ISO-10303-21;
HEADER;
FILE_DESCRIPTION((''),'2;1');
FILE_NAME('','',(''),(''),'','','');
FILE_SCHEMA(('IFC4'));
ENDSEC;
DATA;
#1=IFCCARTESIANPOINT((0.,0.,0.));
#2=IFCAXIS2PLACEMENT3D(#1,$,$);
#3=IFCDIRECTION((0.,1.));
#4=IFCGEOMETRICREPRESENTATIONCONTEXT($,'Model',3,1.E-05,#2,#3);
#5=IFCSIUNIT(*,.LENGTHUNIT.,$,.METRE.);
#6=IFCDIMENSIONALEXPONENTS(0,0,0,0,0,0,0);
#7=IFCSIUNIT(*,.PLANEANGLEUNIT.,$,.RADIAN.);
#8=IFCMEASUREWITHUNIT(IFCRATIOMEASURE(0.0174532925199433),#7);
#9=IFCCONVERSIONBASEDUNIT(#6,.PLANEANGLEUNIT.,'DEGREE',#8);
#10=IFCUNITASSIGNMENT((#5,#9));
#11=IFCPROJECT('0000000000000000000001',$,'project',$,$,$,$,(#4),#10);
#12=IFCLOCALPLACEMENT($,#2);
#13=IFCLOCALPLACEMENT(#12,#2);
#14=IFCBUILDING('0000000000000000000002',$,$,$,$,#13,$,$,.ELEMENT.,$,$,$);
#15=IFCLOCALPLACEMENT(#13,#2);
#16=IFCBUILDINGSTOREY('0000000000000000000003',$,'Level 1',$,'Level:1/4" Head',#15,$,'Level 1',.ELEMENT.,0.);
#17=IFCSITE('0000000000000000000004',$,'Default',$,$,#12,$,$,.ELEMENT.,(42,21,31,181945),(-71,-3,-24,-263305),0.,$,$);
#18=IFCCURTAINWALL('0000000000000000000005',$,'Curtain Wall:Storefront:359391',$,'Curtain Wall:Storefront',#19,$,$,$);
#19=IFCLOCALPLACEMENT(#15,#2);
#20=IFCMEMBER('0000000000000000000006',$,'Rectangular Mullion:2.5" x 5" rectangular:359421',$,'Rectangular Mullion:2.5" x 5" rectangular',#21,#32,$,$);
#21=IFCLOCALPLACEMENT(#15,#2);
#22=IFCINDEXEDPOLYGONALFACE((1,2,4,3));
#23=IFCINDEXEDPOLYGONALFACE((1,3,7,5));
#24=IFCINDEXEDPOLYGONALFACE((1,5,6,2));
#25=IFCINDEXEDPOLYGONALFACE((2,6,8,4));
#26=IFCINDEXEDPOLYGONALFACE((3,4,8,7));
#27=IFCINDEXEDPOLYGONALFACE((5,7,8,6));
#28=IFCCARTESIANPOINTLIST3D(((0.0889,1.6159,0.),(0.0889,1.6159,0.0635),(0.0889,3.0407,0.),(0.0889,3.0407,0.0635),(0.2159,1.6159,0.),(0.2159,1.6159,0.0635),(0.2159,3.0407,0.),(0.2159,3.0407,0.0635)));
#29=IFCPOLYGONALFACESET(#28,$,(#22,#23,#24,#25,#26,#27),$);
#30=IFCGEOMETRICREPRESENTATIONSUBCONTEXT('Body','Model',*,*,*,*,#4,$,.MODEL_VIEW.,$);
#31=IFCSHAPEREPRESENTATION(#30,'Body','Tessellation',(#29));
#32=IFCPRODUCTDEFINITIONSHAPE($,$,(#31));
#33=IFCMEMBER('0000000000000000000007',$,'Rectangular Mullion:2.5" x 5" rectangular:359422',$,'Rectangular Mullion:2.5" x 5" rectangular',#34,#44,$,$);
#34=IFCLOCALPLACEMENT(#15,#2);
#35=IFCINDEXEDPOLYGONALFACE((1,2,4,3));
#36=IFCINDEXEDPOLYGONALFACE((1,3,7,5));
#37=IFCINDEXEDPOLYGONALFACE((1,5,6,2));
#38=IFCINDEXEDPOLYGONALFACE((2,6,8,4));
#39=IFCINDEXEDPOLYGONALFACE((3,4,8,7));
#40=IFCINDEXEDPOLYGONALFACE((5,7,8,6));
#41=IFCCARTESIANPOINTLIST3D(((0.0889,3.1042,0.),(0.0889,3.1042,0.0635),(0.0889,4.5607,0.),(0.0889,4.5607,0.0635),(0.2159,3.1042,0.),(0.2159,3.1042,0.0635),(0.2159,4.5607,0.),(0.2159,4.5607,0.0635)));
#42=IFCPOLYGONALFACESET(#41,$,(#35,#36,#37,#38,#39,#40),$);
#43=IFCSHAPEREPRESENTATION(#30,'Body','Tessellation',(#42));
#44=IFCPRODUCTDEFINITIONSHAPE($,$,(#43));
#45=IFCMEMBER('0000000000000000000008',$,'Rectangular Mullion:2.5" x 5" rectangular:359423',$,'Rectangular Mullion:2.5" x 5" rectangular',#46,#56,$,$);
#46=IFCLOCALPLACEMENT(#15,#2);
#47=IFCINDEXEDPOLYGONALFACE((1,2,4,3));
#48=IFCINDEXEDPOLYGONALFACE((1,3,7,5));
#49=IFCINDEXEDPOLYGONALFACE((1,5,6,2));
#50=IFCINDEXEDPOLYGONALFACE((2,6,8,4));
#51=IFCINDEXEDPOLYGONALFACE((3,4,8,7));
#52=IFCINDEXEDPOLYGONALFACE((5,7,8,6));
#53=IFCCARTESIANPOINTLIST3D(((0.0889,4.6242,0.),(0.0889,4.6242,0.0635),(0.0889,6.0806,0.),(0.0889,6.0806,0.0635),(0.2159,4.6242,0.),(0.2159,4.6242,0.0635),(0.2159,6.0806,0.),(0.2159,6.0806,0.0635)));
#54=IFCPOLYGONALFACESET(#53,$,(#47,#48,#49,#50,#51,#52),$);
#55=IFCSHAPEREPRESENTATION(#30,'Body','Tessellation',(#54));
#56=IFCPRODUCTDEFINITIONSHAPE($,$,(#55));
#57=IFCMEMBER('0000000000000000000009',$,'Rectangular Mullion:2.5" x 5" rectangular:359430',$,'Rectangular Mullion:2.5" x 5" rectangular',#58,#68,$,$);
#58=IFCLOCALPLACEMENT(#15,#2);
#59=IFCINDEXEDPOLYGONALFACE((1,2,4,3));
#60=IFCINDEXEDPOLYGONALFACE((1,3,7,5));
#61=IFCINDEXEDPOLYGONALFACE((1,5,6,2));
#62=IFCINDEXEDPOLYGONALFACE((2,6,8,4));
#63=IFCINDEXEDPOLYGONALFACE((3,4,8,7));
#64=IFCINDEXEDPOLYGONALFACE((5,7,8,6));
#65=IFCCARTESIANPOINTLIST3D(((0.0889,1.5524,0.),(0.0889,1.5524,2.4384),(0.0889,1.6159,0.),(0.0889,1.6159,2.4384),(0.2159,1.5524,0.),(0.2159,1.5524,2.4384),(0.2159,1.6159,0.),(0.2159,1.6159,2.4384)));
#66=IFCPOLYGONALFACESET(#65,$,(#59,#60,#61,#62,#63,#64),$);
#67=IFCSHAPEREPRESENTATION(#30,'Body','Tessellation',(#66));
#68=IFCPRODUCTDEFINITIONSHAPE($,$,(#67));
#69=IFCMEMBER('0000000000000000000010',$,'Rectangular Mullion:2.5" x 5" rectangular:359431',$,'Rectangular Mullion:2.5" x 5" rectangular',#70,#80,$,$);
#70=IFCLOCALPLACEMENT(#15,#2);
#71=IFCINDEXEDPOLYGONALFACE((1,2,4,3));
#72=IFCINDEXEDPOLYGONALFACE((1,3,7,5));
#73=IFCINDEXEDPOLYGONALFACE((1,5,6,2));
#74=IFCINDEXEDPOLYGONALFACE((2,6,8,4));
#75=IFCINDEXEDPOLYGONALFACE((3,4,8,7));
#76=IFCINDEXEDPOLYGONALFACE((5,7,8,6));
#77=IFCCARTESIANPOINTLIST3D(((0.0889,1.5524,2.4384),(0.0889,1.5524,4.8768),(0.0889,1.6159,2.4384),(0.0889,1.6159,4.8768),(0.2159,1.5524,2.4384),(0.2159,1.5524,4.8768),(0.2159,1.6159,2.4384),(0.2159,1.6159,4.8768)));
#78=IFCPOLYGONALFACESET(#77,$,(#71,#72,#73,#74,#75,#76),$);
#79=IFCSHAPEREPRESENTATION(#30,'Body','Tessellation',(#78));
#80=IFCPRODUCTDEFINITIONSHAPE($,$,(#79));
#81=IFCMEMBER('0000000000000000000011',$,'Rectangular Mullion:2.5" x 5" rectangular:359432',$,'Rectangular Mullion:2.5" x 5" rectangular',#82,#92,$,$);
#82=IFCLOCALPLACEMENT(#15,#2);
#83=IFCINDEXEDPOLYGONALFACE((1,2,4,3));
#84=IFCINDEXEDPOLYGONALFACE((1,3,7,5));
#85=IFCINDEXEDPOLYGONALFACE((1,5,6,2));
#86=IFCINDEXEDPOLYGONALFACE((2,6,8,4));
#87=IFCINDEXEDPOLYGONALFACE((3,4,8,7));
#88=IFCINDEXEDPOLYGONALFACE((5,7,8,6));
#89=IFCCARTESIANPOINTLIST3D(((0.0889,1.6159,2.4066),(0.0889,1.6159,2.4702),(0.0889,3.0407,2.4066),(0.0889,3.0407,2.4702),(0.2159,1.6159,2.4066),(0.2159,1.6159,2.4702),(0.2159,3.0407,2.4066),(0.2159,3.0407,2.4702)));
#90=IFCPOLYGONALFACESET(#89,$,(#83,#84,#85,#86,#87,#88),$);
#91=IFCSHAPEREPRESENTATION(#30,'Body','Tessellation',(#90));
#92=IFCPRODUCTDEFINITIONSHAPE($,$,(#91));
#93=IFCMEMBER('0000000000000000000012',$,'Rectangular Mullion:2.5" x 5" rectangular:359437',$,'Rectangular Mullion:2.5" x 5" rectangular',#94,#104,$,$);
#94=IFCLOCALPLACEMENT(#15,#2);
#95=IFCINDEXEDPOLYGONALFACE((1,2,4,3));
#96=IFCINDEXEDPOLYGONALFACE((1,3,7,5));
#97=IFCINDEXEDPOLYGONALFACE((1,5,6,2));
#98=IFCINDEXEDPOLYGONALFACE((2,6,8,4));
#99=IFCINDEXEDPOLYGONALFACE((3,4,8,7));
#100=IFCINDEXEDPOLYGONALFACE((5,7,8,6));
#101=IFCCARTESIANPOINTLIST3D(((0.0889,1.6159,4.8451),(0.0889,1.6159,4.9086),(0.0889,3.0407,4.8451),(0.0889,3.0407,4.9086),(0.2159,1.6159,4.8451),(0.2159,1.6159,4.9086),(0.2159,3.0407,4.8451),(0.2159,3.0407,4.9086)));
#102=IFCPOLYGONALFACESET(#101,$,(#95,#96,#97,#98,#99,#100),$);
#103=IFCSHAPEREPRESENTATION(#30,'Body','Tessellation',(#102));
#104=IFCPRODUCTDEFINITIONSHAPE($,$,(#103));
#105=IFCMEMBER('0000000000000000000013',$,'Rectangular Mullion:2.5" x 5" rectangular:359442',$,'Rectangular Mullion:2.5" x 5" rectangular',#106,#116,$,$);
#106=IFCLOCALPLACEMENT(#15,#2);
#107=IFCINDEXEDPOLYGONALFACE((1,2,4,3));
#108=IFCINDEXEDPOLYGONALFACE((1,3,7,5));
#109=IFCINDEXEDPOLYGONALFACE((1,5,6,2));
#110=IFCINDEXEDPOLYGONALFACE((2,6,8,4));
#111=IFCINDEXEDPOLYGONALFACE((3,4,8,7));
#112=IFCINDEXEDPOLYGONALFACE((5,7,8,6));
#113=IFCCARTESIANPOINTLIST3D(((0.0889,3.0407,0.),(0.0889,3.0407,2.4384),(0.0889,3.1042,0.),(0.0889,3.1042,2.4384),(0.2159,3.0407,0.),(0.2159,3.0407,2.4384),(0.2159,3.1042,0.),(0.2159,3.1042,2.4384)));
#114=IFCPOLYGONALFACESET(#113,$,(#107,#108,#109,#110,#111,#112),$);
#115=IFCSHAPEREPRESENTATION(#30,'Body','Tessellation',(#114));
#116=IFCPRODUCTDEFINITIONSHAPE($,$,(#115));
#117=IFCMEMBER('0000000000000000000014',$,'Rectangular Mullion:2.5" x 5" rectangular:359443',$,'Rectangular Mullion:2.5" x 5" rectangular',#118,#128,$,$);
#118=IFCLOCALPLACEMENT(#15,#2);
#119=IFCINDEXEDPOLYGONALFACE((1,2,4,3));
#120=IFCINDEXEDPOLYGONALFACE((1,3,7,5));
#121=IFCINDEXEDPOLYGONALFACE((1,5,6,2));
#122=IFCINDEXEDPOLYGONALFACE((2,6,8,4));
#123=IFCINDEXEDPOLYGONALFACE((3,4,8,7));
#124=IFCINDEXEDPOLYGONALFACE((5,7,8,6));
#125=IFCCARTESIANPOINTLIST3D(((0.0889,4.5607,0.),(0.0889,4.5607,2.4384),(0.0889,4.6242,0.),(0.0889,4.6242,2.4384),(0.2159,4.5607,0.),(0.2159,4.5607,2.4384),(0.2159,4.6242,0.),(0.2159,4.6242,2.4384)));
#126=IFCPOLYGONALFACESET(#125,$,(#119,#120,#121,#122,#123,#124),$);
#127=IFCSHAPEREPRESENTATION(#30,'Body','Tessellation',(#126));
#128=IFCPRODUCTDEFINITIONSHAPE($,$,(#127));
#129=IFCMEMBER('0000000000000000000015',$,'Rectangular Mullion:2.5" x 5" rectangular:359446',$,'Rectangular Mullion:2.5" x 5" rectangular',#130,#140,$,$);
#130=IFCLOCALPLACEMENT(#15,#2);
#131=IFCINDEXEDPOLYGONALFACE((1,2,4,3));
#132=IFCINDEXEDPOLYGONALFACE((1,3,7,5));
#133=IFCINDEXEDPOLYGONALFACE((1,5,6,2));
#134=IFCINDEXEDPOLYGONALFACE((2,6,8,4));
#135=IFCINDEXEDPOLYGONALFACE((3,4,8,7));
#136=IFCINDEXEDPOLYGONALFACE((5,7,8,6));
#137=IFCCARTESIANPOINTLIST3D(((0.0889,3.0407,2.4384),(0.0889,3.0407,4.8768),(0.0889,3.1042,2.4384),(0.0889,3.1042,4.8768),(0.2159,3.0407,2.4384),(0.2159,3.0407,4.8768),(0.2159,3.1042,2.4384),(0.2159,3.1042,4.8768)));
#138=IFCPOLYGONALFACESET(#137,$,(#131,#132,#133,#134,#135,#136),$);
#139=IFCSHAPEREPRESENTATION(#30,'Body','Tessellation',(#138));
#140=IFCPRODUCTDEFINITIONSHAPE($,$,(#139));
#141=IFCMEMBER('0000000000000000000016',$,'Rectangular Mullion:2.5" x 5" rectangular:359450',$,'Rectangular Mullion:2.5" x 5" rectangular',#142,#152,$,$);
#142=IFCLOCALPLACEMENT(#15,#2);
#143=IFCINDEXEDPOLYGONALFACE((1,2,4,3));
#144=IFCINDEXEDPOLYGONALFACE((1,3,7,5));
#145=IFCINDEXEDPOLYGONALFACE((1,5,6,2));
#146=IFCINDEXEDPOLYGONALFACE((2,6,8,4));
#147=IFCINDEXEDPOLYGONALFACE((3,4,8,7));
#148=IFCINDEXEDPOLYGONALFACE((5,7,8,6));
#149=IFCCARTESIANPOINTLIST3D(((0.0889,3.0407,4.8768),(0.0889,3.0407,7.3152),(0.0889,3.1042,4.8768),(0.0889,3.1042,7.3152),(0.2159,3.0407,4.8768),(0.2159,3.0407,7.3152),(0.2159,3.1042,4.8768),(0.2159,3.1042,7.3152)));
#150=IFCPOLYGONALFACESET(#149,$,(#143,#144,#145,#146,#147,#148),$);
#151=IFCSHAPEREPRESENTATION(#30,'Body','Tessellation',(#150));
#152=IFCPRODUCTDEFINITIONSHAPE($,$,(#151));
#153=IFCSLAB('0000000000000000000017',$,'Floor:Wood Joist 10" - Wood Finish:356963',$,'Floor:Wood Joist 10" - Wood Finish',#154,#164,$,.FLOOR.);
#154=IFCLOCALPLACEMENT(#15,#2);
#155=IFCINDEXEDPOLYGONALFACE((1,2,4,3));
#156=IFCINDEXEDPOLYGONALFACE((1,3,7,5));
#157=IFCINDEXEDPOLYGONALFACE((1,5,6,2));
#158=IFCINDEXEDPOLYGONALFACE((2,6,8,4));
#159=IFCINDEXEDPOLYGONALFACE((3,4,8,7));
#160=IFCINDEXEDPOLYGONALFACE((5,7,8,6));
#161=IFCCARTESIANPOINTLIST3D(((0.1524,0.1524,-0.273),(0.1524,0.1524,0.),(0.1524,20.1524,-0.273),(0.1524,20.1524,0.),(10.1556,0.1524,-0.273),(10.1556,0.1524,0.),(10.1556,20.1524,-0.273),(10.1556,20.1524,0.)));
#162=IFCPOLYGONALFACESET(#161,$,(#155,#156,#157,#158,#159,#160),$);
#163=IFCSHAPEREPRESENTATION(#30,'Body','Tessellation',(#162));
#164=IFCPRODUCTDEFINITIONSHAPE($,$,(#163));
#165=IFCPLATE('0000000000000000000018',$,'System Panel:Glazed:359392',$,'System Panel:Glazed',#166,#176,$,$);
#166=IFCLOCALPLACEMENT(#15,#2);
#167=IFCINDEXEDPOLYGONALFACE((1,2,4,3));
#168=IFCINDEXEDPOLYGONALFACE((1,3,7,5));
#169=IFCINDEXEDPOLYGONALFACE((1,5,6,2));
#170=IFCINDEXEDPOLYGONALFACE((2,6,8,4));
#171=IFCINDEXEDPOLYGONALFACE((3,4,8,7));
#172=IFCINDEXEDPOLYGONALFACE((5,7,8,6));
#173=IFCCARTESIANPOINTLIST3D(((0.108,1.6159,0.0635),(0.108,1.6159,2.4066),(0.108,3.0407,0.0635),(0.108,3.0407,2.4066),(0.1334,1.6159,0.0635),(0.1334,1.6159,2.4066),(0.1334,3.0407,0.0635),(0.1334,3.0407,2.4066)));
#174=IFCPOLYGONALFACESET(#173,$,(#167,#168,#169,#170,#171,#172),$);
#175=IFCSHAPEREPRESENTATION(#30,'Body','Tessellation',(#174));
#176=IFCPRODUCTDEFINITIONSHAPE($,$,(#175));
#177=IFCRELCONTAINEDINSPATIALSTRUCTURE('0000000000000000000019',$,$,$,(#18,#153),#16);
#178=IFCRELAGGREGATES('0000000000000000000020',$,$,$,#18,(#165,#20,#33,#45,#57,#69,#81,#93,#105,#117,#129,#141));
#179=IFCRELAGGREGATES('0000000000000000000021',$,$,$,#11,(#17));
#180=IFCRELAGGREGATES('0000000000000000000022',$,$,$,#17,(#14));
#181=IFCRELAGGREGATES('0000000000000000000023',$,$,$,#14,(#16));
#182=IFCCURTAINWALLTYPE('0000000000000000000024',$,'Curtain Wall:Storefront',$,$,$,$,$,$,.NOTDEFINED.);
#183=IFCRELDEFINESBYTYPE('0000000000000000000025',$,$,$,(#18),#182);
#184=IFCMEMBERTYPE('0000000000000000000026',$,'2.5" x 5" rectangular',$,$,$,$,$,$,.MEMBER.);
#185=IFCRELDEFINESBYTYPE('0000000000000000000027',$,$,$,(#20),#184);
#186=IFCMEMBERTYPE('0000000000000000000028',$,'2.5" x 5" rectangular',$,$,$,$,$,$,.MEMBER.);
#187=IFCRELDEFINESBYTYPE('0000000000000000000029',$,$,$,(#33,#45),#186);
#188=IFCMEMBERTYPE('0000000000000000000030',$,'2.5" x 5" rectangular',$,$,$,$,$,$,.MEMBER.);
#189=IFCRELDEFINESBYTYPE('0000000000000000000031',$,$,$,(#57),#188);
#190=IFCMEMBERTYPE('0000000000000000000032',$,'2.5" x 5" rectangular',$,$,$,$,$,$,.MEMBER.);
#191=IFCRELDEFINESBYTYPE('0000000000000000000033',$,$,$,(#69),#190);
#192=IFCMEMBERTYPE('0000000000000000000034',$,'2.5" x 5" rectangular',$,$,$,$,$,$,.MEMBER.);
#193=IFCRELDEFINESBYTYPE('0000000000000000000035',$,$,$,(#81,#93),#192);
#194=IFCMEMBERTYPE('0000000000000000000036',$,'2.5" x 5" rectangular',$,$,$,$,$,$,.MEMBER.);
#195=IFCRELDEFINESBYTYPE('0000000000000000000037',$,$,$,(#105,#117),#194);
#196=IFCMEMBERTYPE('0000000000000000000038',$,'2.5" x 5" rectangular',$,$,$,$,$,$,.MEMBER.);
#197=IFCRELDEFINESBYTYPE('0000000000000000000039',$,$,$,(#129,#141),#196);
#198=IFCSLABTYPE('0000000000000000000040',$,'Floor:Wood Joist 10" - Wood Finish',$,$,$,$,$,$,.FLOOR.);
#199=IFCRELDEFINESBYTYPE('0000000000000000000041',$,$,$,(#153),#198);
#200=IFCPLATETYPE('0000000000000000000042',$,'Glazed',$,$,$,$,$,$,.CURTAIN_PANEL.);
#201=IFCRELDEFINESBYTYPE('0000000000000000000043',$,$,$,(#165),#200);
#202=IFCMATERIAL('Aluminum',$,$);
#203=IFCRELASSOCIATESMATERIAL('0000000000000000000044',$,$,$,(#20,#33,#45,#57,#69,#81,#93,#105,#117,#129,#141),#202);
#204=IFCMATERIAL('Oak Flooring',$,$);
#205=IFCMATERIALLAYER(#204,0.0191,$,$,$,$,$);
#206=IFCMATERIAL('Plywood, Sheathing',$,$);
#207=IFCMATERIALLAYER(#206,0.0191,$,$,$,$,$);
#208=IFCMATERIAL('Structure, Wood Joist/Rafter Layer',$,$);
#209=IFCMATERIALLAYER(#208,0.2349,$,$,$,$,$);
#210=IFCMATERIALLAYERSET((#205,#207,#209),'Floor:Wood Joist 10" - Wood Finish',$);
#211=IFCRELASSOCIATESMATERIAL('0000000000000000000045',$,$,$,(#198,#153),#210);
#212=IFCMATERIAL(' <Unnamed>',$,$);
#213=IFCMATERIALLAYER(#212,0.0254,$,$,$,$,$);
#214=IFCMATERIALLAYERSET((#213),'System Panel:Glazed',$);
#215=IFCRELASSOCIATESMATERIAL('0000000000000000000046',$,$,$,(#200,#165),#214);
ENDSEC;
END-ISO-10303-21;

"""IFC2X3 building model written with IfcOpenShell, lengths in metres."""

from ifc_helpers import new_model, entity, si_unit, converted_unit, direction, frame, frame_2d, origin, origin_2d_with_axis, place, context, subcontext, project, spatial, rectangle, extrude, source, transform, mapped, material, layer, layer_set, layer_usage, type_object, type_shapes, element, aggregate, save


model = new_model("IFC2X3")

# Units and contexts
model_context = context("Model", 3, precision=1e-05, world=origin(), true_north=direction((0.0, 1.0)))
body_context = subcontext(model_context, "Body", "Model", "MODEL_VIEW")
ifc_project = project(units=[si_unit("LENGTHUNIT", "METRE"), converted_unit("PLANEANGLEUNIT", "DEGREE", entity("IfcRatioMeasure", 0.0174532925199433), si_unit("PLANEANGLEUNIT", "RADIAN"), dimensions=[0, 0, 0, 0, 0, 0, 0])], contexts=[model_context])

# Site, building, storey
site_placement = place(None, origin())
site = spatial("IfcSite", under=ifc_project, at=site_placement, Name="Default", CompositionType="ELEMENT", RefLatitude=(42, 21, 31, 181945), RefLongitude=(-71, -3, -24, -263305), RefElevation=0.0)
building_placement = place(site_placement, origin())
building = spatial("IfcBuilding", under=site, at=building_placement, CompositionType="ELEMENT")
storey_placement = place(building_placement, origin())
storey = spatial("IfcBuildingStorey", under=building, at=storey_placement, Name="Level 1", ObjectType="Level:1/4\" Head", LongName="Level 1", CompositionType="ELEMENT", Elevation=0.0)

# Curtain wall, members
curtain_wall_type = type_object("IfcCurtainWallType", Name="Curtain Wall:Storefront", PredefinedType="NOTDEFINED")
curtain_wall_placement = place(storey_placement, origin())
curtain_wall = element("IfcCurtainWall", 1, at=curtain_wall_placement, inside=storey, type_object=curtain_wall_type, Name="Curtain Wall:Storefront:359391", ObjectType="Curtain Wall:Storefront")
ifc_material_1 = material(Name="Aluminum")
member_type_1 = type_object("IfcMemberType", Name="2.5\" x 5\" rectangular", PredefinedType="MEMBER")
shared_shape_1 = source(origin(), body_context, "Body", "SweptSolid", [
    extrude(rectangle(XDim=0.127, YDim=0.0635, at=origin_2d_with_axis()), frame((-0.0318, 0.0, -1.4248), z_axis=(0.0, 0.0, 1.0), x_axis=(0.0, -1.0, 0.0)), (0.0, 0.0, 1.0), 1.4248),
])
type_shapes(member_type_1, [shared_shape_1])
member_1_placement = place(storey_placement, frame((0.1524, 1.6159, 0.0), z_axis=(0.0, -1.0, 0.0), x_axis=(0.0, 0.0, -1.0)))
member_1 = element("IfcMember", 2, at=member_1_placement, type_object=member_type_1, material=ifc_material_1, Name="Rectangular Mullion:2.5\" x 5\" rectangular:359421", ObjectType="Rectangular Mullion:2.5\" x 5\" rectangular", context=body_context, shape_type="MappedRepresentation", body=[
    mapped(shared_shape_1, transform((0.0, 0.0, 0.0), scale=1.0)),
])
member_type_2 = type_object("IfcMemberType", Name="2.5\" x 5\" rectangular", PredefinedType="MEMBER")
shared_shape_2 = source(origin(), body_context, "Body", "SweptSolid", [
    extrude(rectangle(XDim=0.127, YDim=0.0635, at=origin_2d_with_axis()), frame((-0.0318, 0.0, -1.4565), z_axis=(0.0, 0.0, 1.0), x_axis=(0.0, -1.0, 0.0)), (0.0, 0.0, 1.0), 1.4565),
])
type_shapes(member_type_2, [shared_shape_2])
member_2_placement = place(storey_placement, frame((0.1524, 3.1042, 0.0), z_axis=(0.0, -1.0, 0.0), x_axis=(0.0, 0.0, -1.0)))
member_2 = element("IfcMember", 3, at=member_2_placement, type_object=member_type_2, material=ifc_material_1, Name="Rectangular Mullion:2.5\" x 5\" rectangular:359422", ObjectType="Rectangular Mullion:2.5\" x 5\" rectangular", context=body_context, shape_type="MappedRepresentation", body=[
    mapped(shared_shape_2, transform((0.0, 0.0, 0.0), scale=1.0)),
])
member_3_placement = place(storey_placement, frame((0.1524, 4.6242, 0.0), z_axis=(0.0, -1.0, 0.0), x_axis=(0.0, 0.0, -1.0)))
member_3 = element("IfcMember", 4, at=member_3_placement, type_object=member_type_2, material=ifc_material_1, Name="Rectangular Mullion:2.5\" x 5\" rectangular:359423", ObjectType="Rectangular Mullion:2.5\" x 5\" rectangular", context=body_context, shape_type="MappedRepresentation", body=[
    mapped(shared_shape_2, transform((0.0, 0.0, 0.0), scale=1.0)),
])
member_type_3 = type_object("IfcMemberType", Name="2.5\" x 5\" rectangular", PredefinedType="MEMBER")
shared_shape_3 = source(origin(), body_context, "Body", "SweptSolid", [
    extrude(rectangle(XDim=0.127, YDim=0.0635, at=origin_2d_with_axis()), frame((-0.0318, 0.0, -2.4384), z_axis=(0.0, 0.0, 1.0), x_axis=(0.0, -1.0, 0.0)), (0.0, 0.0, 1.0), 2.4384),
])
type_shapes(member_type_3, [shared_shape_3])
member_4_placement = place(storey_placement, frame((0.1524, 1.5524, 2.4384), z_axis=(0.0, 0.0, 1.0), x_axis=(0.0, -1.0, 0.0)))
member_4 = element("IfcMember", 5, at=member_4_placement, type_object=member_type_3, material=ifc_material_1, Name="Rectangular Mullion:2.5\" x 5\" rectangular:359430", ObjectType="Rectangular Mullion:2.5\" x 5\" rectangular", context=body_context, shape_type="MappedRepresentation", body=[
    mapped(shared_shape_3, transform((0.0, 0.0, 0.0), scale=1.0)),
])
member_type_4 = type_object("IfcMemberType", Name="2.5\" x 5\" rectangular", PredefinedType="MEMBER")
shared_shape_4 = source(origin(), body_context, "Body", "SweptSolid", [
    extrude(rectangle(XDim=0.127, YDim=0.0635, at=origin_2d_with_axis()), frame((-0.0318, 0.0, -2.4384), z_axis=(0.0, 0.0, 1.0), x_axis=(0.0, -1.0, 0.0)), (0.0, 0.0, 1.0), 2.4384),
])
type_shapes(member_type_4, [shared_shape_4])
member_5_placement = place(storey_placement, frame((0.1524, 1.5524, 4.8768), z_axis=(0.0, 0.0, 1.0), x_axis=(0.0, -1.0, 0.0)))
member_5 = element("IfcMember", 6, at=member_5_placement, type_object=member_type_4, material=ifc_material_1, Name="Rectangular Mullion:2.5\" x 5\" rectangular:359431", ObjectType="Rectangular Mullion:2.5\" x 5\" rectangular", context=body_context, shape_type="MappedRepresentation", body=[
    mapped(shared_shape_4, transform((0.0, 0.0, 0.0), scale=1.0)),
])
member_type_5 = type_object("IfcMemberType", Name="2.5\" x 5\" rectangular", PredefinedType="MEMBER")
shared_shape_5 = source(origin(), body_context, "Body", "SweptSolid", [
    extrude(rectangle(XDim=0.127, YDim=0.0635, at=origin_2d_with_axis()), frame((0.0, 0.0, -1.4248), z_axis=(0.0, 0.0, 1.0), x_axis=(0.0, -1.0, 0.0)), (0.0, 0.0, 1.0), 1.4248),
])
type_shapes(member_type_5, [shared_shape_5])
member_6_placement = place(storey_placement, frame((0.1524, 3.0407, 2.4384), z_axis=(0.0, 1.0, 0.0), x_axis=(0.0, 0.0, 1.0)))
member_6 = element("IfcMember", 7, at=member_6_placement, type_object=member_type_5, material=ifc_material_1, Name="Rectangular Mullion:2.5\" x 5\" rectangular:359432", ObjectType="Rectangular Mullion:2.5\" x 5\" rectangular", context=body_context, shape_type="MappedRepresentation", body=[
    mapped(shared_shape_5, transform((0.0, 0.0, 0.0), scale=1.0)),
])
member_7_placement = place(storey_placement, frame((0.1524, 3.0407, 4.8768), z_axis=(0.0, 1.0, 0.0), x_axis=(0.0, 0.0, 1.0)))
member_7 = element("IfcMember", 8, at=member_7_placement, type_object=member_type_5, material=ifc_material_1, Name="Rectangular Mullion:2.5\" x 5\" rectangular:359437", ObjectType="Rectangular Mullion:2.5\" x 5\" rectangular", context=body_context, shape_type="MappedRepresentation", body=[
    mapped(shared_shape_5, transform((0.0, 0.0, 0.0), scale=1.0)),
])
member_type_6 = type_object("IfcMemberType", Name="2.5\" x 5\" rectangular", PredefinedType="MEMBER")
shared_shape_6 = source(origin(), body_context, "Body", "SweptSolid", [
    extrude(rectangle(XDim=0.127, YDim=0.0635, at=origin_2d_with_axis()), frame((0.0, 0.0, -2.4384), z_axis=(0.0, 0.0, 1.0), x_axis=(0.0, -1.0, 0.0)), (0.0, 0.0, 1.0), 2.4384),
])
type_shapes(member_type_6, [shared_shape_6])
member_8_placement = place(storey_placement, frame((0.1524, 3.0724, 0.0), z_axis=(0.0, 0.0, -1.0), x_axis=(0.0, 1.0, 0.0)))
member_8 = element("IfcMember", 9, at=member_8_placement, type_object=member_type_6, material=ifc_material_1, Name="Rectangular Mullion:2.5\" x 5\" rectangular:359442", ObjectType="Rectangular Mullion:2.5\" x 5\" rectangular", context=body_context, shape_type="MappedRepresentation", body=[
    mapped(shared_shape_6, transform((0.0, 0.0, 0.0), scale=1.0)),
])
member_9_placement = place(storey_placement, frame((0.1524, 4.5924, 0.0), z_axis=(0.0, 0.0, -1.0), x_axis=(0.0, 1.0, 0.0)))
member_9 = element("IfcMember", 10, at=member_9_placement, type_object=member_type_6, material=ifc_material_1, Name="Rectangular Mullion:2.5\" x 5\" rectangular:359443", ObjectType="Rectangular Mullion:2.5\" x 5\" rectangular", context=body_context, shape_type="MappedRepresentation", body=[
    mapped(shared_shape_6, transform((0.0, 0.0, 0.0), scale=1.0)),
])
member_type_7 = type_object("IfcMemberType", Name="2.5\" x 5\" rectangular", PredefinedType="MEMBER")
shared_shape_7 = source(origin(), body_context, "Body", "SweptSolid", [
    extrude(rectangle(XDim=0.127, YDim=0.0635, at=origin_2d_with_axis()), frame((0.0, 0.0, -2.4384), z_axis=(0.0, 0.0, 1.0), x_axis=(0.0, -1.0, 0.0)), (0.0, 0.0, 1.0), 2.4384),
])
type_shapes(member_type_7, [shared_shape_7])
member_10_placement = place(storey_placement, frame((0.1524, 3.0724, 2.4384), z_axis=(0.0, 0.0, -1.0), x_axis=(0.0, 1.0, 0.0)))
member_10 = element("IfcMember", 11, at=member_10_placement, type_object=member_type_7, material=ifc_material_1, Name="Rectangular Mullion:2.5\" x 5\" rectangular:359446", ObjectType="Rectangular Mullion:2.5\" x 5\" rectangular", context=body_context, shape_type="MappedRepresentation", body=[
    mapped(shared_shape_7, transform((0.0, 0.0, 0.0), scale=1.0)),
])
member_11_placement = place(storey_placement, frame((0.1524, 3.0724, 4.8768), z_axis=(0.0, 0.0, -1.0), x_axis=(0.0, 1.0, 0.0)))
member_11 = element("IfcMember", 12, at=member_11_placement, type_object=member_type_7, material=ifc_material_1, Name="Rectangular Mullion:2.5\" x 5\" rectangular:359450", ObjectType="Rectangular Mullion:2.5\" x 5\" rectangular", context=body_context, shape_type="MappedRepresentation", body=[
    mapped(shared_shape_7, transform((0.0, 0.0, 0.0), scale=1.0)),
])

# Slab
ifc_material_2 = material(Name="Oak Flooring")
ifc_layer_1 = layer(ifc_material_2, 0.0191)
ifc_material_3 = material(Name="Plywood, Sheathing")
ifc_layer_2 = layer(ifc_material_3, 0.0191)
ifc_material_4 = material(Name="Structure, Wood Joist/Rafter Layer")
ifc_layer_3 = layer(ifc_material_4, 0.2349)
ifc_layer_set_1 = layer_set([ifc_layer_1, ifc_layer_2, ifc_layer_3], Name="Floor:Wood Joist 10\" - Wood Finish")
ifc_layer_usage_1 = layer_usage(ifc_layer_set_1, "AXIS3", "POSITIVE", 0.0)
slab_type_1 = type_object("IfcSlabType", Name="Floor:Wood Joist 10\" - Wood Finish", PredefinedType="FLOOR", material=ifc_layer_set_1)
slab_1_placement = place(storey_placement, origin())
element("IfcSlab", 13, at=slab_1_placement, inside=storey, type_object=slab_type_1, material=ifc_layer_usage_1, Name="Floor:Wood Joist 10\" - Wood Finish:356963", ObjectType="Floor:Wood Joist 10\" - Wood Finish", PredefinedType="FLOOR", context=body_context, shape_type="SweptSolid", body=[
    extrude(rectangle(XDim=20.0, YDim=10.0032, at=origin_2d_with_axis()), frame((5.154, 10.1524, 0.0), z_axis=(0.0, 0.0, -1.0), x_axis=(0.0, 1.0, 0.0)), (0.0, 0.0, 1.0), 0.2731),
])

# Plate
ifc_material_5 = material(Name=" <Unnamed>")
ifc_layer_4 = layer(ifc_material_5, 0.0254)
ifc_layer_set_2 = layer_set([ifc_layer_4], Name="System Panel:Glazed")
ifc_layer_usage_2 = layer_usage(ifc_layer_set_2, "AXIS3", "POSITIVE", 0.1042)
plate_type_1 = type_object("IfcPlateType", Name="Glazed", PredefinedType="CURTAIN_PANEL", material=ifc_layer_set_2)
shared_shape_8 = source(origin(), body_context, "Body", "SweptSolid", [
    extrude(rectangle(XDim=0.0254, YDim=1.4248, at=frame_2d((0.0, 0.0), x_axis=(1.0, 0.0))), frame((0.7124, 0.0127, 0.0), z_axis=(0.0, 0.0, 1.0), x_axis=(0.0, 1.0, 0.0)), (0.0, 0.0, 1.0), 2.3432),
])
type_shapes(plate_type_1, [shared_shape_8])
plate_1_placement = place(curtain_wall_placement, frame((0.1334, 1.6159, 0.0635), z_axis=(0.0, 0.0, 1.0), x_axis=(0.0, 1.0, 0.0)))
plate_1 = element("IfcPlate", 14, at=plate_1_placement, type_object=plate_type_1, material=ifc_layer_usage_2, Name="System Panel:Glazed:359392", ObjectType="System Panel:Glazed", context=body_context, shape_type="MappedRepresentation", body=[
    mapped(shared_shape_8, transform((0.0, 0.0, 0.0), scale=1.0)),
])
aggregate(curtain_wall, [plate_1, member_1, member_2, member_3, member_4, member_5, member_6, member_7, member_8, member_9, member_10, member_11])

save(model, "model.ifc")
